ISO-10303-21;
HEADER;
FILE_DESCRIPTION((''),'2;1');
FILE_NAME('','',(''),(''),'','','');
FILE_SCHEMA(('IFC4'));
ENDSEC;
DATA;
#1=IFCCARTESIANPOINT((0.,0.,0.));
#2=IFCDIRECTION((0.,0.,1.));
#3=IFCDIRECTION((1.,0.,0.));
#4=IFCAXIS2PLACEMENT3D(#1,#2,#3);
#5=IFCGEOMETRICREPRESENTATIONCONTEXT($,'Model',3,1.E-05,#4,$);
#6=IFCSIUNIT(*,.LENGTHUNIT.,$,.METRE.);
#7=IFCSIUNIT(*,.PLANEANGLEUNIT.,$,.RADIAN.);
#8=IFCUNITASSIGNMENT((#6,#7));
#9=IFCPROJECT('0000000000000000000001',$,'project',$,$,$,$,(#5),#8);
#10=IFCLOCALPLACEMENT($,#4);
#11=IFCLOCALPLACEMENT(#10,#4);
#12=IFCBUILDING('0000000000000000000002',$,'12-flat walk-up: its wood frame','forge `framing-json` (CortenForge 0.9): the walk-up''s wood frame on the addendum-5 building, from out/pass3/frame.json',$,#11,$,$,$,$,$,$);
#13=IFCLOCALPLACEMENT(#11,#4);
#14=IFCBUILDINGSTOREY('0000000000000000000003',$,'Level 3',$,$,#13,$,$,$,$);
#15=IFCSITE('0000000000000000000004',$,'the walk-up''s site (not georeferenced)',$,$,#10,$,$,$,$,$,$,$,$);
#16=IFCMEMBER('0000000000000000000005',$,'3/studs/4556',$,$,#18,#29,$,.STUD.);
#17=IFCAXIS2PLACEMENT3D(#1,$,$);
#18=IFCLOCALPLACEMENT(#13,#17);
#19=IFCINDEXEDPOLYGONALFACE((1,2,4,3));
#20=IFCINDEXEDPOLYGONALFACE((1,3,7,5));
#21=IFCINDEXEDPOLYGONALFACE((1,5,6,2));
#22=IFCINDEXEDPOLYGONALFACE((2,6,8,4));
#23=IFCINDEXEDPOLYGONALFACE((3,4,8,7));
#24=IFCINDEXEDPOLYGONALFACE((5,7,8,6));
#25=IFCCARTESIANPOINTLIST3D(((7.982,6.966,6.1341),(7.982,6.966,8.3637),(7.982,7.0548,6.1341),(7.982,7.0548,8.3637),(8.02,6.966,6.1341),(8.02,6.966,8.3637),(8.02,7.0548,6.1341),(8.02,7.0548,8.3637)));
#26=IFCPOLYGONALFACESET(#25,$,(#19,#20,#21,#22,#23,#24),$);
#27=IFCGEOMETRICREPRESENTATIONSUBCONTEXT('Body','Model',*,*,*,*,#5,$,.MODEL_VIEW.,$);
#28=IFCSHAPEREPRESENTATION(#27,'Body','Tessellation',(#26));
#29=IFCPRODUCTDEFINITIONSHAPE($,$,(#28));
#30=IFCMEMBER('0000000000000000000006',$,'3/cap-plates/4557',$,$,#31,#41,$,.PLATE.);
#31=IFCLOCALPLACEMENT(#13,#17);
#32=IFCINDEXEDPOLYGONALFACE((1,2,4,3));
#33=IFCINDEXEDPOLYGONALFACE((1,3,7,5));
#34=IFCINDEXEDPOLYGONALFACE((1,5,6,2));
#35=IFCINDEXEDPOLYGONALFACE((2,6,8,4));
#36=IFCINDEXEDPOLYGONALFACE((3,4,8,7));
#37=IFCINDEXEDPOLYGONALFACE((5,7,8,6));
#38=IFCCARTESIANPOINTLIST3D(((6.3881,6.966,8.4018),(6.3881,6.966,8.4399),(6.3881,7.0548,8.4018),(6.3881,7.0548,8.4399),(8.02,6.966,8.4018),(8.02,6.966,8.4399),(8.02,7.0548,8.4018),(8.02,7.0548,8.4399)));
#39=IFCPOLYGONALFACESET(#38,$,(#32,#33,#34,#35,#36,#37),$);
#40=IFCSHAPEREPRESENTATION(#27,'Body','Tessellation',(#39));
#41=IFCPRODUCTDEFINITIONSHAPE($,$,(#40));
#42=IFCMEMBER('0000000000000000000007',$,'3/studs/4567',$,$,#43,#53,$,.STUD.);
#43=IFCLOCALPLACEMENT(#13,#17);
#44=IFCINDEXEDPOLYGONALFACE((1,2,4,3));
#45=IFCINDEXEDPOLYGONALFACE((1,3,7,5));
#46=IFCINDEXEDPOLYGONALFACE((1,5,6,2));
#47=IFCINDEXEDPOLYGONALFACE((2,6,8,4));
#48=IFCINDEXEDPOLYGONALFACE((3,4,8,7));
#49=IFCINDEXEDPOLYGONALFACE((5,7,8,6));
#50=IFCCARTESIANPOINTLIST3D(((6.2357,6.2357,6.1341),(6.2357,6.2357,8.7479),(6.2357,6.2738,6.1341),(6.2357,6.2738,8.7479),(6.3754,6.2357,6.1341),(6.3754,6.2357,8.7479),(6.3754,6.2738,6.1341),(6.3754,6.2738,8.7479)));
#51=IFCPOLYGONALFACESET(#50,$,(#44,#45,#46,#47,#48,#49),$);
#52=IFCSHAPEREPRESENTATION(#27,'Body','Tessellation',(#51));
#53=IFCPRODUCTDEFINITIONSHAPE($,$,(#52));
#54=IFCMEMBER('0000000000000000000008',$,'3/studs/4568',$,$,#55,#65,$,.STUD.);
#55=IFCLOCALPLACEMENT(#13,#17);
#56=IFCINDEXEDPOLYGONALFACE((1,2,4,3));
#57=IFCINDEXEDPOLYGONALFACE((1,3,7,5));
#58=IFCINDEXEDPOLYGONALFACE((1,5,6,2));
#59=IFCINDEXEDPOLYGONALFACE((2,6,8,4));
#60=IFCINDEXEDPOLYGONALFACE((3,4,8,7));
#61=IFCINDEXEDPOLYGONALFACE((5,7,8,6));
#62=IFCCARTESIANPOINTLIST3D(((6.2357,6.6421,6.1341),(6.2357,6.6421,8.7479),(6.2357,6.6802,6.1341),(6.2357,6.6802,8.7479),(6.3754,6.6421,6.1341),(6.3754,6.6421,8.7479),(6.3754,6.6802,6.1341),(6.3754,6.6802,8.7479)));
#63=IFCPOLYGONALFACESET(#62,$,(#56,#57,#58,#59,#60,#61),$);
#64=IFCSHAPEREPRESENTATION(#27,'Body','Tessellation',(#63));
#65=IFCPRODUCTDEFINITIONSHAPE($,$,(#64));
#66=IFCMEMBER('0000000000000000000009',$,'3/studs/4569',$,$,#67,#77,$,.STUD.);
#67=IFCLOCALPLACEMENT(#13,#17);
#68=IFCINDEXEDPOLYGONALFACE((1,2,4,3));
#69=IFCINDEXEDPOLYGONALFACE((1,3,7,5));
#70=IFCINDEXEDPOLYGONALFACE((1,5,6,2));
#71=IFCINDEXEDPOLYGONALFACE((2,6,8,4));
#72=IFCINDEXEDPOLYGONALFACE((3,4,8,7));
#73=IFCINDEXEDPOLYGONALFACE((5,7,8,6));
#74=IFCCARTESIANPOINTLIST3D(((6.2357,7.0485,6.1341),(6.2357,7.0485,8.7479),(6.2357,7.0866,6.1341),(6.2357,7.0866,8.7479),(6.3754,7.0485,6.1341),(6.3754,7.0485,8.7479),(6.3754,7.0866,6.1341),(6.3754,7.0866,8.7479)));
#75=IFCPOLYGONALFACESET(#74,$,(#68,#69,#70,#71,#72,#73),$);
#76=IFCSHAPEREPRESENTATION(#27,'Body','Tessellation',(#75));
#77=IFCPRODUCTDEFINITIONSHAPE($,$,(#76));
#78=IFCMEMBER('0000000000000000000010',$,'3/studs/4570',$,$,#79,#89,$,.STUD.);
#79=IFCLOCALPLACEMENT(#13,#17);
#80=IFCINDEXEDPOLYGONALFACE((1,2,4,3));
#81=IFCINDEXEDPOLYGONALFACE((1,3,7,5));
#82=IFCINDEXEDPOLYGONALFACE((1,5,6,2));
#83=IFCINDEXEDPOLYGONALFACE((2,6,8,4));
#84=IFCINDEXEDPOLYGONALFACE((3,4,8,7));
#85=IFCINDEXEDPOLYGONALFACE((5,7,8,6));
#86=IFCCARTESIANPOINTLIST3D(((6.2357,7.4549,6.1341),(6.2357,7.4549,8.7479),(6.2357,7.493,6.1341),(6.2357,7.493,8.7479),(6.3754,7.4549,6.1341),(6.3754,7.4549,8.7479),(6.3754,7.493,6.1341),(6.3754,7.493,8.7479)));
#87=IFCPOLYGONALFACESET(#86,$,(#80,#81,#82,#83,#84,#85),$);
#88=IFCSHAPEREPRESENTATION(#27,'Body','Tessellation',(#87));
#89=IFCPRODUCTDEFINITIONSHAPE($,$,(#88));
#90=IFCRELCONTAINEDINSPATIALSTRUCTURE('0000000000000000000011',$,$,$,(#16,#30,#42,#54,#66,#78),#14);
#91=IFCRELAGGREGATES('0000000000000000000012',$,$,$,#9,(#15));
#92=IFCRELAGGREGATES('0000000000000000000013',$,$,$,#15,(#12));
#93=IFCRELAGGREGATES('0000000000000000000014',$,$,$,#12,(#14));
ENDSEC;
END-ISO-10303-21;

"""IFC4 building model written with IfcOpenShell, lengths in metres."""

from ifc_helpers import new_model, si_unit, frame, frame_2d, origin, origin_with_axes, place, context, subcontext, project, spatial, rectangle, extrude, element, save


model = new_model("IFC4")

# Units and contexts
model_context = context("Model", 3, precision=1e-05, world=origin_with_axes())
body_context = subcontext(model_context, "Body", "Model", "MODEL_VIEW")
ifc_project = project(units=[si_unit("LENGTHUNIT", "METRE"), si_unit("PLANEANGLEUNIT", "RADIAN")], contexts=[model_context])

# Site, building, storey
site_placement = place(None, origin_with_axes())
site = spatial("IfcSite", under=ifc_project, at=site_placement, Name="the walk-up's site (not georeferenced)")
building_placement = place(site_placement, origin_with_axes())
building = spatial("IfcBuilding", under=site, at=building_placement, Name="12-flat walk-up: its wood frame", Description="forge `framing-json` (CortenForge 0.9): the walk-up's wood frame on the addendum-5 building, from out/pass3/frame.json")
storey_placement = place(building_placement, origin_with_axes())
storey = spatial("IfcBuildingStorey", under=building, at=storey_placement, Name="Level 3")

# Members
member_1_placement = place(storey_placement, frame((7.982, 6.966, 6.1341), z_axis=(0.0, 0.0, 1.0), x_axis=(1.0, 0.0, 0.0)))
element("IfcMember", 1, at=member_1_placement, inside=storey, Name="3/studs/4556", PredefinedType="STUD", context=body_context, shape_type="SweptSolid", body=[
    extrude(rectangle(XDim=0.0381, YDim=0.0889, at=frame_2d((0.019, 0.0444))), origin(), (0.0, 0.0, 1.0), 2.2296),
])
member_2_placement = place(storey_placement, frame((6.3881, 6.966, 8.4018), z_axis=(0.0, 0.0, 1.0), x_axis=(1.0, 0.0, 0.0)))
element("IfcMember", 2, at=member_2_placement, inside=storey, Name="3/cap-plates/4557", PredefinedType="PLATE", context=body_context, shape_type="SweptSolid", body=[
    extrude(rectangle(XDim=1.6319, YDim=0.0889, at=frame_2d((0.816, 0.0444))), origin(), (0.0, 0.0, 1.0), 0.0381),
])
for number, where, z_axis, x_axis, name in (
    (3, (6.2357, 6.2357, 6.1341), (0.0, 0.0, 1.0), (1.0, 0.0, 0.0), "3/studs/4567"),
    (4, (6.2357, 6.6421, 6.1341), (0.0, 0.0, 1.0), (1.0, 0.0, 0.0), "3/studs/4568"),
    (5, (6.2357, 7.0485, 6.1341), (0.0, 0.0, 1.0), (1.0, 0.0, 0.0), "3/studs/4569"),
    (6, (6.2357, 7.4549, 6.1341), (0.0, 0.0, 1.0), (1.0, 0.0, 0.0), "3/studs/4570"),
):
    element("IfcMember", number, at=place(storey_placement, frame(where, z_axis=z_axis, x_axis=x_axis)), inside=storey, Name=name, PredefinedType="STUD", context=body_context, shape_type="SweptSolid", body=[
        extrude(rectangle(XDim=0.1397, YDim=0.0381, at=frame_2d((0.0699, 0.0191))), origin(), (0.0, 0.0, 1.0), 2.6138),
    ])

save(model, "model.ifc")
